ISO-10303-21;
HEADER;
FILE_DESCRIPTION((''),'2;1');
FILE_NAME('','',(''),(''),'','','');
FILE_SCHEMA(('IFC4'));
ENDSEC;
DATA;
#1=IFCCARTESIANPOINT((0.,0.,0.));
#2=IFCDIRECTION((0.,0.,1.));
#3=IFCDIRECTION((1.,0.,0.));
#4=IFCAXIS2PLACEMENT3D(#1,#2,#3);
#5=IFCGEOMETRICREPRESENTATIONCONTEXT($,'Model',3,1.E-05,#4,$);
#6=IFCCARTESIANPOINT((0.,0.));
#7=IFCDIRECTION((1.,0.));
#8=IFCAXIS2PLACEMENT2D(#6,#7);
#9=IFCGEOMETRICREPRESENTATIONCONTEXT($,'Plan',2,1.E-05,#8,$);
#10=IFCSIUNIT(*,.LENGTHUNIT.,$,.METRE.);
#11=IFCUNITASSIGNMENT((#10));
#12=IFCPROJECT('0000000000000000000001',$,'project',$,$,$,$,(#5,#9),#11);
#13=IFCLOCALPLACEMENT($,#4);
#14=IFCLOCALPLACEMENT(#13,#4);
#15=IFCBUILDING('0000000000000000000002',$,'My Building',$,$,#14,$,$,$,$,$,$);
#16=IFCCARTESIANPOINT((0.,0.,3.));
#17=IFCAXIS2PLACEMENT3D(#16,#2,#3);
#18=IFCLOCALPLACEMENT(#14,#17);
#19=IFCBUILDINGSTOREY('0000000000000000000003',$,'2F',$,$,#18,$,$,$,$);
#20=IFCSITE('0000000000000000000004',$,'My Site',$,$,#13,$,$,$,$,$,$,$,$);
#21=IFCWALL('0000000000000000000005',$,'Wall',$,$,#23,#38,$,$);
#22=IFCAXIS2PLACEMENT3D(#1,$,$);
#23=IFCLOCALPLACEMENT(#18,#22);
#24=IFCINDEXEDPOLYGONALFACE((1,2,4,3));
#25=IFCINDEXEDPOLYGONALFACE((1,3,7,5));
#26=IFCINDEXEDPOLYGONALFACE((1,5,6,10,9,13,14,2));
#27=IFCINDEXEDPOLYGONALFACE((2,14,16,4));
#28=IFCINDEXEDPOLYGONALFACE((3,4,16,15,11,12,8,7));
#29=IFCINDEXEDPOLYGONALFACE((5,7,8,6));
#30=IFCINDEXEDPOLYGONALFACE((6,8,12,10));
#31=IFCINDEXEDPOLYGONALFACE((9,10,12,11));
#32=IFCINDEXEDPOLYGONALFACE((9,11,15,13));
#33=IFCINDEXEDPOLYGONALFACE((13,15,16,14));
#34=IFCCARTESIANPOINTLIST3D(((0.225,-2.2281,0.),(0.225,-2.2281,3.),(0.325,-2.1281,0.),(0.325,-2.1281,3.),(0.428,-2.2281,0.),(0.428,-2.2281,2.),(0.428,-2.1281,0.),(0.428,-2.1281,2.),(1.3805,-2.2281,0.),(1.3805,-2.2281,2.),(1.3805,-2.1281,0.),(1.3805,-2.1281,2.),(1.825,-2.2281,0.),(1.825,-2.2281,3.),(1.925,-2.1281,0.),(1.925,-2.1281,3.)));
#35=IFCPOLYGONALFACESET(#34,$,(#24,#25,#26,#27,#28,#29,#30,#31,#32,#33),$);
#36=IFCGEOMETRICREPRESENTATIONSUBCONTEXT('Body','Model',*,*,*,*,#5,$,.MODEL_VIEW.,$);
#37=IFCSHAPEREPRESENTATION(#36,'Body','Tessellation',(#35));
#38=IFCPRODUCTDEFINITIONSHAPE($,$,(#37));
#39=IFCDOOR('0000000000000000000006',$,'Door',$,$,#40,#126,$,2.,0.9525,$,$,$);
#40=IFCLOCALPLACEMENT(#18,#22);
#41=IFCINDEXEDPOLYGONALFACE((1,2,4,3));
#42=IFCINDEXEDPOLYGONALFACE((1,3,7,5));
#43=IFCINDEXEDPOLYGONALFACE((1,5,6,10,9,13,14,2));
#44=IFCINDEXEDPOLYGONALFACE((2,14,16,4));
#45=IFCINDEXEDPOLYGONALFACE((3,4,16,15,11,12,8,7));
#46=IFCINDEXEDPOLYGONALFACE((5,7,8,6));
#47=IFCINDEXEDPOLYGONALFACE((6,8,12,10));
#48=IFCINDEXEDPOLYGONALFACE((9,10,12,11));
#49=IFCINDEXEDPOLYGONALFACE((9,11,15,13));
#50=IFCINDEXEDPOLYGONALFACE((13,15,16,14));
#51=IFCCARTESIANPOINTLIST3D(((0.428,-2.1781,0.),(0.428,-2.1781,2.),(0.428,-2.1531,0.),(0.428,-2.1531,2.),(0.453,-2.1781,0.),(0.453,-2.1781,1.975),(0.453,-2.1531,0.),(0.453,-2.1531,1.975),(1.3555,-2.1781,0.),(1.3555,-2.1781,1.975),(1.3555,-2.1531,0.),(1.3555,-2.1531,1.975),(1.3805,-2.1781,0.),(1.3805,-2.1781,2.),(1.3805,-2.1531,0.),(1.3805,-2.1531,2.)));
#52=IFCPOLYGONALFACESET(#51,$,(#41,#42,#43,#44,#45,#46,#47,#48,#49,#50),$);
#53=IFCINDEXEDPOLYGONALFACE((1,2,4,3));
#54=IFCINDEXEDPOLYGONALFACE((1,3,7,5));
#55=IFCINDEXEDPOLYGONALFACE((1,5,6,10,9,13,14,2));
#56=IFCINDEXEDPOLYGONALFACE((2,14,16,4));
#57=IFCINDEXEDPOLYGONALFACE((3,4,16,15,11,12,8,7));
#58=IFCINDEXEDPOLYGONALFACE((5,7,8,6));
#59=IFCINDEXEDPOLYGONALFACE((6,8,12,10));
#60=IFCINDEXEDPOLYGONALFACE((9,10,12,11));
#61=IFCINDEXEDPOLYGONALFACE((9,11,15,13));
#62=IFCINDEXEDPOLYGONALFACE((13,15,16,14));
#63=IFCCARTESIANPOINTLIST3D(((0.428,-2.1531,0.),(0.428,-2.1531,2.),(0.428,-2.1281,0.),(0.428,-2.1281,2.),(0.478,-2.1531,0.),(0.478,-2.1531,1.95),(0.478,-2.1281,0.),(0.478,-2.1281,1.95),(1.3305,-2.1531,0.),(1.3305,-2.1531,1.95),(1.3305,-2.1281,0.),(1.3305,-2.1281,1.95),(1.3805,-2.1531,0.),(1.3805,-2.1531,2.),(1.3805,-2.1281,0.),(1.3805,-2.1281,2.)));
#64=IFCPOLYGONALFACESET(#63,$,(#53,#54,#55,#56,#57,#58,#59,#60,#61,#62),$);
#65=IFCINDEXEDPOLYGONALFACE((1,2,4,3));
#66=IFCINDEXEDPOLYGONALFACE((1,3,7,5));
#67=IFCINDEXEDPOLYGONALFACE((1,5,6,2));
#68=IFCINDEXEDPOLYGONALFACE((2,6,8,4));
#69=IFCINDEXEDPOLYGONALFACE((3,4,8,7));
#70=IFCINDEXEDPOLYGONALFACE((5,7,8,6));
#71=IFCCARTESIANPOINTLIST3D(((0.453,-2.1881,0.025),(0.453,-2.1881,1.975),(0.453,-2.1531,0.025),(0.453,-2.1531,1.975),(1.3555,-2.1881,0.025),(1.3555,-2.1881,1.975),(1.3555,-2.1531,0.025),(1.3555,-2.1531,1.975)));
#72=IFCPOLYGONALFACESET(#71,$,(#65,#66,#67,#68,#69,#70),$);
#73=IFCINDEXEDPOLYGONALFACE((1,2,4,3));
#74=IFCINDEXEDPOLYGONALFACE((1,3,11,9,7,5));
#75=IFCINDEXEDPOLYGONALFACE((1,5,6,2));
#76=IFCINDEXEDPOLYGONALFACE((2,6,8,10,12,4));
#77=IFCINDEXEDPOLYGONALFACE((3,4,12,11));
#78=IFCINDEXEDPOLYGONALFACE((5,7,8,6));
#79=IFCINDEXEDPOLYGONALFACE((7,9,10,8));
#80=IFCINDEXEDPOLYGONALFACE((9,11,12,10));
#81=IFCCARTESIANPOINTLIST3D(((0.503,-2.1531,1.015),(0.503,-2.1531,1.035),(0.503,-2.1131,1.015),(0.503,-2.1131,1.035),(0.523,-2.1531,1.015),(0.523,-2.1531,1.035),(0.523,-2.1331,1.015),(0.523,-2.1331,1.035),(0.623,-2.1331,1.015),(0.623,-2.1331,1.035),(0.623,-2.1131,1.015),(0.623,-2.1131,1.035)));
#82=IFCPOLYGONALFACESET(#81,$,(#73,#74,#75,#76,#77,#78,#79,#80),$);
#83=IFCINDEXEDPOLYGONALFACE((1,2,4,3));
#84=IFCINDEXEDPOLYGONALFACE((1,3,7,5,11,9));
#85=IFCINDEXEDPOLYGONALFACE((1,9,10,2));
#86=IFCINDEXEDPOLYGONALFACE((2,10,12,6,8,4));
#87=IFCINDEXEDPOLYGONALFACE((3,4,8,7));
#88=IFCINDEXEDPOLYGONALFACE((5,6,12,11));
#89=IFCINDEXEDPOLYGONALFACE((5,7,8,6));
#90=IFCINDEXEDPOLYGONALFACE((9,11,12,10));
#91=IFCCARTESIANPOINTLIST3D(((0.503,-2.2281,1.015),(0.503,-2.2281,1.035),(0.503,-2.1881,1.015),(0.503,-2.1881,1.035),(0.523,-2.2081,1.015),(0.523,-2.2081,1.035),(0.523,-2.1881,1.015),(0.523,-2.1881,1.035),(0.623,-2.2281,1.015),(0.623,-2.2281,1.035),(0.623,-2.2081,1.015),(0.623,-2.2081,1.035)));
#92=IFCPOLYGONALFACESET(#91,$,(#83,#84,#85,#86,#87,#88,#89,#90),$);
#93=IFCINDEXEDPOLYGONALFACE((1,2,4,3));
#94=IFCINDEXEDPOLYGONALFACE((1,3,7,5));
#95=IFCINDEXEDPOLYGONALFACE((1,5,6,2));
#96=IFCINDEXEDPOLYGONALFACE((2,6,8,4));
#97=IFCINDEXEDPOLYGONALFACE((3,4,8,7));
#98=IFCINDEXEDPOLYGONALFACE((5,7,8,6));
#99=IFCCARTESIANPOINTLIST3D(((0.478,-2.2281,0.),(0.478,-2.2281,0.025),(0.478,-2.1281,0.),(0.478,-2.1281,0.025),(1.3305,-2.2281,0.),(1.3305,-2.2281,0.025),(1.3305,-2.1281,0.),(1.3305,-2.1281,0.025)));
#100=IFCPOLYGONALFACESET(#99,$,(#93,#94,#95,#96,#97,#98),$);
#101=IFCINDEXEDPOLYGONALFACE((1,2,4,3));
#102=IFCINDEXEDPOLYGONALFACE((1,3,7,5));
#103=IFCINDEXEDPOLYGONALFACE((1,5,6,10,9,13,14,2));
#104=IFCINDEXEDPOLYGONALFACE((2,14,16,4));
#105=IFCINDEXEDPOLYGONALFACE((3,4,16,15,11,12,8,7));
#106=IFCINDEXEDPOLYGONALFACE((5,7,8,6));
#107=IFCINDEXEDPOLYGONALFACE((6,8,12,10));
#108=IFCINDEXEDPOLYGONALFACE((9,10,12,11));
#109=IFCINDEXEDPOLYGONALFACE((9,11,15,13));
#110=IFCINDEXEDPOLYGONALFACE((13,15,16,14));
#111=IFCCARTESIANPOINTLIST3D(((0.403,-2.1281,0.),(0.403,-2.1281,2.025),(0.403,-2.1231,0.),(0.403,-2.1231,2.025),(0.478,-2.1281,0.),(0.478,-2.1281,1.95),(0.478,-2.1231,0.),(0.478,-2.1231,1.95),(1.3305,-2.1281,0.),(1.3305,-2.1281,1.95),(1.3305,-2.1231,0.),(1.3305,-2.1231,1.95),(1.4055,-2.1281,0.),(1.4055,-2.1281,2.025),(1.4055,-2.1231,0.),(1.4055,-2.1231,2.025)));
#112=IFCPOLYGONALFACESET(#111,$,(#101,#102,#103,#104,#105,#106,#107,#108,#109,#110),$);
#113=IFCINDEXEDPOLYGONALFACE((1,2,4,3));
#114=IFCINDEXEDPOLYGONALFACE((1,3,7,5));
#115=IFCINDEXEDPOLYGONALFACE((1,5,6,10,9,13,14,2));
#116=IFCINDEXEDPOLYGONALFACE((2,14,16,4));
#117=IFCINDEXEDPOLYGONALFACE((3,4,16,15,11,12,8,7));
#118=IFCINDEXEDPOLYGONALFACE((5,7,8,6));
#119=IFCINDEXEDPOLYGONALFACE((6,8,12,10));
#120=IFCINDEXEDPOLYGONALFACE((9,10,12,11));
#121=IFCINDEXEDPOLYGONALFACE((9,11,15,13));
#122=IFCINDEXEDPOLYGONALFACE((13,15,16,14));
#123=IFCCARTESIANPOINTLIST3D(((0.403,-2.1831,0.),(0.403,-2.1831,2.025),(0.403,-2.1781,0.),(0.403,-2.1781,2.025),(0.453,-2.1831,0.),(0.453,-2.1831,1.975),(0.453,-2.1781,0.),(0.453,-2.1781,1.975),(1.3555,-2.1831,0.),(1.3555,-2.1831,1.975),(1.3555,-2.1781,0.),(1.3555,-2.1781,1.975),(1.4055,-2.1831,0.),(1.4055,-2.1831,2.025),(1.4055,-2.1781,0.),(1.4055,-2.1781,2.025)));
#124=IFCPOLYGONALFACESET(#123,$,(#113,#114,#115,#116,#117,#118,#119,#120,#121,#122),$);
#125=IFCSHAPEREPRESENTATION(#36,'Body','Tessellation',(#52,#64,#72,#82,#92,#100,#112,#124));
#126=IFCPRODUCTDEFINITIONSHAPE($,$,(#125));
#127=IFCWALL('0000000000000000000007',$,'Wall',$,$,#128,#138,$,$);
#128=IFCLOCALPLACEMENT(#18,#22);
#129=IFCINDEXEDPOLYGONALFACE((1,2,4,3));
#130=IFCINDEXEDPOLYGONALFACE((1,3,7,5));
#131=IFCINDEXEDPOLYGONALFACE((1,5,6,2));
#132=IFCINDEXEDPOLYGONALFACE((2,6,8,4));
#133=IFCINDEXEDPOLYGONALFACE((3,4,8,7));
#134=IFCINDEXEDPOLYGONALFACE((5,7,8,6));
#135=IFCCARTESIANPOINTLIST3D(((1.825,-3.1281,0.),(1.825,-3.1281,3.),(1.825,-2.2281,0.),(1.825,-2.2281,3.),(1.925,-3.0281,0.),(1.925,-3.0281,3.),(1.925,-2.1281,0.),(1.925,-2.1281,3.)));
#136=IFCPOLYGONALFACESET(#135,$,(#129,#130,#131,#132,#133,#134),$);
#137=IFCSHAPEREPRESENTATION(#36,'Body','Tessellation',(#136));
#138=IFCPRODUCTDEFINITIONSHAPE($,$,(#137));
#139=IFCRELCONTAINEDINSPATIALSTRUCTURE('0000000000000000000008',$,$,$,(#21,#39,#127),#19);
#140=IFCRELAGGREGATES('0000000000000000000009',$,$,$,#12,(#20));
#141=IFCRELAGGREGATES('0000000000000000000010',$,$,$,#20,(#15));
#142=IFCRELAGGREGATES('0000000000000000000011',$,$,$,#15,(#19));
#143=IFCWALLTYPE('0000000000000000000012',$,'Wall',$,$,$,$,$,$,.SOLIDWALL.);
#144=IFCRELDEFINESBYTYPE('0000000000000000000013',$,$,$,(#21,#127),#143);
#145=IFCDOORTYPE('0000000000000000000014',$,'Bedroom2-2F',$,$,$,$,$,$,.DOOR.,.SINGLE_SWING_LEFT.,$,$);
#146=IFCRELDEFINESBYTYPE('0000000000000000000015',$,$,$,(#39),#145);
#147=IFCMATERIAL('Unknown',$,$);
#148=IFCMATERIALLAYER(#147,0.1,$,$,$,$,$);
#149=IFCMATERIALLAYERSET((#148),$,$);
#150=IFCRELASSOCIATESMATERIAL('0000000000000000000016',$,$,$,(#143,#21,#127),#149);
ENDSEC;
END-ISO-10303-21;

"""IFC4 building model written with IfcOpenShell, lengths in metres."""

from ifc_helpers import new_model, entity, si_unit, frame, origin_with_axes, origin_2d_with_axis, place, context, subcontext, project, spatial, line, indexed_curve, outline, extrude, shape, source, transform, mapped, material, layer, layer_set, layer_usage, type_object, type_shapes, element, fill, save


model = new_model("IFC4")

# Units and contexts
model_context = context("Model", 3, precision=1e-05, world=origin_with_axes())
plan_context = context("Plan", 2, precision=1e-05, world=origin_2d_with_axis())
body_context_1 = subcontext(model_context, "Body", "Model", "MODEL_VIEW")
body_context_2 = subcontext(plan_context, "Body", "Plan", "PLAN_VIEW")
ifc_project = project(units=[si_unit("LENGTHUNIT", "METRE")], contexts=[model_context, plan_context])

# Site, building, storey
site_placement = place(None, origin_with_axes())
site = spatial("IfcSite", under=ifc_project, at=site_placement, Name="My Site")
building_placement = place(site_placement, origin_with_axes())
building = spatial("IfcBuilding", under=site, at=building_placement, Name="My Building")
storey_placement = place(building_placement, frame((0.0, 0.0, 3.0), z_axis=(0.0, 0.0, 1.0), x_axis=(1.0, 0.0, 0.0)))
storey = spatial("IfcBuildingStorey", under=building, at=storey_placement, Name="2F")

# Shared definitions
ifc_material = material(Name="Unknown")

# Shared definitions
ifc_layer_1 = layer(ifc_material, 0.1)
ifc_layer_set_1 = layer_set([ifc_layer_1])
wall_type = type_object("IfcWallType", Name="Wall", PredefinedType="SOLIDWALL", material=ifc_layer_set_1)

# Wall, opening, door
ifc_layer_usage_1 = layer_usage(ifc_layer_set_1, "AXIS2", "POSITIVE", 0.0)
wall_1_placement = place(storey_placement, frame((0.225, -2.2281, 0.0), z_axis=(0.0, 0.0, 1.0), x_axis=(1.0, 0.0, 0.0)))
wall_1 = element("IfcWall", 1, at=wall_1_placement, inside=storey, type_object=wall_type, material=ifc_layer_usage_1, Name="Wall", context=body_context_1, shape_type="SweptSolid", body=[
    extrude(outline(indexed_curve([(0.0, 0.0), (0.1, 0.1), (1.7, 0.1), (1.6, 0.0)], segments=[line(1, 2, 3, 4, 1)])), origin_with_axes(), (0.0, 0.0, 1.0), 3.0),
])
shared_shape_1 = source(origin_with_axes(), body_context_1, "Body", "SweptSolid", [
    extrude(outline(indexed_curve([(0.0, 0.0), (0.9525, 0.0), (0.9525, 2.0), (0.0, 2.0)], segments=[line(1, 2, 3, 4, 1)])), frame((0.0, -0.6, 0.0), z_axis=(0.0, -1.0, 0.0), x_axis=(1.0, 0.0, 0.0)), (0.0, 0.0, -1.0), 1.2),
])
opening_1_placement = place(wall_1_placement, frame((1.1555, 0.1, 0.0), z_axis=(0.0, 0.0, 1.0), x_axis=(-1.0, 0.0, 0.0)))
opening_1 = element("IfcOpeningElement", 2, at=opening_1_placement, cuts=wall_1, PredefinedType="OPENING", context=body_context_1, shape_type="MappedRepresentation", body=[
    mapped(shared_shape_1, transform((0.0, 0.0, 0.0), x_axis=(1.0, 0.0, 0.0), y_axis=(0.0, 1.0, 0.0), z_axis=(0.0, 0.0, 1.0), scale=1.0)),
])
door_type_1 = type_object("IfcDoorType", Name="Bedroom2-2F", OperationType="SINGLE_SWING_LEFT", PredefinedType="DOOR")
shared_shape_2 = source(origin_with_axes(), body_context_1, "Body", "SweptSolid", [
    extrude(outline(indexed_curve([(0.0, 0.0), (0.0, 2.0), (0.9525, 2.0), (0.9525, 0.0), (0.9275, 0.0), (0.9275, 1.975), (0.025, 1.975), (0.025, 0.0)], segments=[line(1, 2, 3, 4, 5, 6, 7, 8, 1)])), frame((0.0, 0.025, 0.0), z_axis=(0.0, -1.0, 0.0), x_axis=(1.0, 0.0, 0.0)), (0.0, 0.0, -1.0), 0.025),
    extrude(outline(indexed_curve([(0.0, 0.0), (0.0, 2.0), (0.9525, 2.0), (0.9525, 0.0), (0.9025, 0.0), (0.9025, 1.95), (0.05, 1.95), (0.05, 0.0)], segments=[line(1, 2, 3, 4, 5, 6, 7, 8, 1)])), frame((0.0, 0.0, 0.0), z_axis=(0.0, -1.0, 0.0), x_axis=(1.0, 0.0, 0.0)), (0.0, 0.0, -1.0), 0.025),
    extrude(outline(indexed_curve([(0.0, 0.0), (0.9025, 0.0), (0.9025, 0.035), (0.0, 0.035)], segments=[line(1, 2, 3, 4, 1)])), frame((0.025, 0.025, 0.025), z_axis=(0.0, 0.0, 1.0), x_axis=(1.0, 0.0, 0.0)), (0.0, 0.0, 1.0), 1.95),
    extrude(outline(indexed_curve([(0.0, 0.0), (0.0, -0.04), (-0.12, -0.04), (-0.12, -0.02), (-0.02, -0.02), (-0.02, 0.0)], segments=[line(1, 2, 3, 4, 5, 6, 1)])), frame((0.8775, 0.025, 1.015), z_axis=(0.0, 0.0, 1.0), x_axis=(1.0, 0.0, 0.0)), (0.0, 0.0, 1.0), 0.02),
    extrude(outline(indexed_curve([(0.0, 0.0), (0.0, 0.04), (-0.12, 0.04), (-0.12, 0.02), (-0.02, 0.02), (-0.02, 0.0)], segments=[line(1, 2, 3, 4, 5, 6, 1)])), frame((0.8775, 0.06, 1.015), z_axis=(0.0, 0.0, 1.0), x_axis=(1.0, 0.0, 0.0)), (0.0, 0.0, 1.0), 0.02),
    extrude(outline(indexed_curve([(0.0, 0.0), (0.8525, 0.0), (0.8525, 0.1), (0.0, 0.1)], segments=[line(1, 2, 3, 4, 1)])), frame((0.05, 0.0, 0.0), z_axis=(0.0, 0.0, 1.0), x_axis=(1.0, 0.0, 0.0)), (0.0, 0.0, 1.0), 0.025),
    extrude(outline(indexed_curve([(0.0, 0.0), (0.0, 2.025), (1.0025, 2.025), (1.0025, 0.0), (0.9275, 0.0), (0.9275, 1.95), (0.075, 1.95), (0.075, 0.0)], segments=[line(1, 2, 3, 4, 5, 6, 7, 8, 1)])), frame((-0.025, -0.005, 0.0), z_axis=(0.0, -1.0, 0.0), x_axis=(1.0, 0.0, 0.0)), (0.0, 0.0, -1.0), 0.005),
    extrude(outline(indexed_curve([(0.0, 0.0), (0.0, 2.025), (1.0025, 2.025), (1.0025, 0.0), (0.9525, 0.0), (0.9525, 1.975), (0.05, 1.975), (0.05, 0.0)], segments=[line(1, 2, 3, 4, 5, 6, 7, 8, 1)])), frame((-0.025, 0.05, 0.0), z_axis=(0.0, -1.0, 0.0), x_axis=(1.0, 0.0, 0.0)), (0.0, 0.0, -1.0), 0.005),
])
shared_shape_3 = source(origin_with_axes(), body_context_2, "Body", "Curve2D", [
    entity("IfcIndexedPolyCurve", entity("IfcCartesianPointList2D", [[0.0, 0.0], [0.0, 0.05], [0.025, 0.05], [0.025, 0.025], [0.05, 0.025], [0.05, 0.0]]), [entity("IfcLineIndex", [1, 2, 3, 4, 5, 6, 1])]),
    entity("IfcIndexedPolyCurve", entity("IfcCartesianPointList2D", [[0.9525, 0.0], [0.9525, 0.05], [0.9275, 0.05], [0.9275, 0.025], [0.9025, 0.025], [0.9025, 0.0]]), [entity("IfcLineIndex", [1, 2, 3, 4, 5, 6, 1])]),
    entity("IfcTrimmedCurve", entity("IfcEllipse", entity("IfcAxis2Placement2D", entity("IfcCartesianPoint", [0.06, 0.05]), entity("IfcDirection", [1.0, 0.0])), 0.8675, 0.9025), [entity("IfcCartesianPoint", [0.9275, 0.05])], [entity("IfcCartesianPoint", [0.06, 0.9525])], True, "CARTESIAN"),
    entity("IfcIndexedPolyCurve", entity("IfcCartesianPointList2D", [[0.025, 0.05], [0.06, 0.05], [0.06, 0.9525], [0.025, 0.9525]]), [entity("IfcLineIndex", [1, 2, 3, 4, 1])]),
])
type_shapes(door_type_1, [shared_shape_2, shared_shape_3])
door_1_placement = place(opening_1_placement, frame((0.0, 0.0, 0.0), z_axis=(0.0, 0.0, 1.0), x_axis=(1.0, 0.0, 0.0)))
door_1 = element("IfcDoor", 3, at=door_1_placement, inside=storey, type_object=door_type_1, Name="Door", OverallHeight=2.0, OverallWidth=0.9525, shapes=[
    shape(body_context_1, "Body", "MappedRepresentation", [mapped(shared_shape_2, transform((0.0, 0.0, 0.0), x_axis=(1.0, 0.0, 0.0), y_axis=(0.0, 1.0, 0.0), z_axis=(0.0, 0.0, 1.0), scale=1.0))]),
    shape(body_context_2, "Body", "MappedRepresentation", [mapped(shared_shape_3, transform((0.0, 0.0, 0.0), x_axis=(1.0, 0.0, 0.0), y_axis=(0.0, 1.0, 0.0), z_axis=(0.0, 0.0, 1.0), scale=1.0))]),
])
fill(opening_1, door_1)

# Wall
ifc_layer_usage_2 = layer_usage(ifc_layer_set_1, "AXIS2", "POSITIVE", 0.0)
wall_2_placement = place(storey_placement, frame((1.825, -2.2281, 0.0), z_axis=(0.0, 0.0, 1.0), x_axis=(0.0, -1.0, 0.0)))
element("IfcWall", 4, at=wall_2_placement, inside=storey, type_object=wall_type, material=ifc_layer_usage_2, Name="Wall", context=body_context_1, shape_type="SweptSolid", body=[
    extrude(outline(indexed_curve([(0.0, 0.0), (-0.1, 0.1), (0.8, 0.1), (0.9, 0.0)], segments=[line(1, 2, 3, 4, 1)])), origin_with_axes(), (0.0, 0.0, 1.0), 3.0),
])

save(model, "model.ifc")
